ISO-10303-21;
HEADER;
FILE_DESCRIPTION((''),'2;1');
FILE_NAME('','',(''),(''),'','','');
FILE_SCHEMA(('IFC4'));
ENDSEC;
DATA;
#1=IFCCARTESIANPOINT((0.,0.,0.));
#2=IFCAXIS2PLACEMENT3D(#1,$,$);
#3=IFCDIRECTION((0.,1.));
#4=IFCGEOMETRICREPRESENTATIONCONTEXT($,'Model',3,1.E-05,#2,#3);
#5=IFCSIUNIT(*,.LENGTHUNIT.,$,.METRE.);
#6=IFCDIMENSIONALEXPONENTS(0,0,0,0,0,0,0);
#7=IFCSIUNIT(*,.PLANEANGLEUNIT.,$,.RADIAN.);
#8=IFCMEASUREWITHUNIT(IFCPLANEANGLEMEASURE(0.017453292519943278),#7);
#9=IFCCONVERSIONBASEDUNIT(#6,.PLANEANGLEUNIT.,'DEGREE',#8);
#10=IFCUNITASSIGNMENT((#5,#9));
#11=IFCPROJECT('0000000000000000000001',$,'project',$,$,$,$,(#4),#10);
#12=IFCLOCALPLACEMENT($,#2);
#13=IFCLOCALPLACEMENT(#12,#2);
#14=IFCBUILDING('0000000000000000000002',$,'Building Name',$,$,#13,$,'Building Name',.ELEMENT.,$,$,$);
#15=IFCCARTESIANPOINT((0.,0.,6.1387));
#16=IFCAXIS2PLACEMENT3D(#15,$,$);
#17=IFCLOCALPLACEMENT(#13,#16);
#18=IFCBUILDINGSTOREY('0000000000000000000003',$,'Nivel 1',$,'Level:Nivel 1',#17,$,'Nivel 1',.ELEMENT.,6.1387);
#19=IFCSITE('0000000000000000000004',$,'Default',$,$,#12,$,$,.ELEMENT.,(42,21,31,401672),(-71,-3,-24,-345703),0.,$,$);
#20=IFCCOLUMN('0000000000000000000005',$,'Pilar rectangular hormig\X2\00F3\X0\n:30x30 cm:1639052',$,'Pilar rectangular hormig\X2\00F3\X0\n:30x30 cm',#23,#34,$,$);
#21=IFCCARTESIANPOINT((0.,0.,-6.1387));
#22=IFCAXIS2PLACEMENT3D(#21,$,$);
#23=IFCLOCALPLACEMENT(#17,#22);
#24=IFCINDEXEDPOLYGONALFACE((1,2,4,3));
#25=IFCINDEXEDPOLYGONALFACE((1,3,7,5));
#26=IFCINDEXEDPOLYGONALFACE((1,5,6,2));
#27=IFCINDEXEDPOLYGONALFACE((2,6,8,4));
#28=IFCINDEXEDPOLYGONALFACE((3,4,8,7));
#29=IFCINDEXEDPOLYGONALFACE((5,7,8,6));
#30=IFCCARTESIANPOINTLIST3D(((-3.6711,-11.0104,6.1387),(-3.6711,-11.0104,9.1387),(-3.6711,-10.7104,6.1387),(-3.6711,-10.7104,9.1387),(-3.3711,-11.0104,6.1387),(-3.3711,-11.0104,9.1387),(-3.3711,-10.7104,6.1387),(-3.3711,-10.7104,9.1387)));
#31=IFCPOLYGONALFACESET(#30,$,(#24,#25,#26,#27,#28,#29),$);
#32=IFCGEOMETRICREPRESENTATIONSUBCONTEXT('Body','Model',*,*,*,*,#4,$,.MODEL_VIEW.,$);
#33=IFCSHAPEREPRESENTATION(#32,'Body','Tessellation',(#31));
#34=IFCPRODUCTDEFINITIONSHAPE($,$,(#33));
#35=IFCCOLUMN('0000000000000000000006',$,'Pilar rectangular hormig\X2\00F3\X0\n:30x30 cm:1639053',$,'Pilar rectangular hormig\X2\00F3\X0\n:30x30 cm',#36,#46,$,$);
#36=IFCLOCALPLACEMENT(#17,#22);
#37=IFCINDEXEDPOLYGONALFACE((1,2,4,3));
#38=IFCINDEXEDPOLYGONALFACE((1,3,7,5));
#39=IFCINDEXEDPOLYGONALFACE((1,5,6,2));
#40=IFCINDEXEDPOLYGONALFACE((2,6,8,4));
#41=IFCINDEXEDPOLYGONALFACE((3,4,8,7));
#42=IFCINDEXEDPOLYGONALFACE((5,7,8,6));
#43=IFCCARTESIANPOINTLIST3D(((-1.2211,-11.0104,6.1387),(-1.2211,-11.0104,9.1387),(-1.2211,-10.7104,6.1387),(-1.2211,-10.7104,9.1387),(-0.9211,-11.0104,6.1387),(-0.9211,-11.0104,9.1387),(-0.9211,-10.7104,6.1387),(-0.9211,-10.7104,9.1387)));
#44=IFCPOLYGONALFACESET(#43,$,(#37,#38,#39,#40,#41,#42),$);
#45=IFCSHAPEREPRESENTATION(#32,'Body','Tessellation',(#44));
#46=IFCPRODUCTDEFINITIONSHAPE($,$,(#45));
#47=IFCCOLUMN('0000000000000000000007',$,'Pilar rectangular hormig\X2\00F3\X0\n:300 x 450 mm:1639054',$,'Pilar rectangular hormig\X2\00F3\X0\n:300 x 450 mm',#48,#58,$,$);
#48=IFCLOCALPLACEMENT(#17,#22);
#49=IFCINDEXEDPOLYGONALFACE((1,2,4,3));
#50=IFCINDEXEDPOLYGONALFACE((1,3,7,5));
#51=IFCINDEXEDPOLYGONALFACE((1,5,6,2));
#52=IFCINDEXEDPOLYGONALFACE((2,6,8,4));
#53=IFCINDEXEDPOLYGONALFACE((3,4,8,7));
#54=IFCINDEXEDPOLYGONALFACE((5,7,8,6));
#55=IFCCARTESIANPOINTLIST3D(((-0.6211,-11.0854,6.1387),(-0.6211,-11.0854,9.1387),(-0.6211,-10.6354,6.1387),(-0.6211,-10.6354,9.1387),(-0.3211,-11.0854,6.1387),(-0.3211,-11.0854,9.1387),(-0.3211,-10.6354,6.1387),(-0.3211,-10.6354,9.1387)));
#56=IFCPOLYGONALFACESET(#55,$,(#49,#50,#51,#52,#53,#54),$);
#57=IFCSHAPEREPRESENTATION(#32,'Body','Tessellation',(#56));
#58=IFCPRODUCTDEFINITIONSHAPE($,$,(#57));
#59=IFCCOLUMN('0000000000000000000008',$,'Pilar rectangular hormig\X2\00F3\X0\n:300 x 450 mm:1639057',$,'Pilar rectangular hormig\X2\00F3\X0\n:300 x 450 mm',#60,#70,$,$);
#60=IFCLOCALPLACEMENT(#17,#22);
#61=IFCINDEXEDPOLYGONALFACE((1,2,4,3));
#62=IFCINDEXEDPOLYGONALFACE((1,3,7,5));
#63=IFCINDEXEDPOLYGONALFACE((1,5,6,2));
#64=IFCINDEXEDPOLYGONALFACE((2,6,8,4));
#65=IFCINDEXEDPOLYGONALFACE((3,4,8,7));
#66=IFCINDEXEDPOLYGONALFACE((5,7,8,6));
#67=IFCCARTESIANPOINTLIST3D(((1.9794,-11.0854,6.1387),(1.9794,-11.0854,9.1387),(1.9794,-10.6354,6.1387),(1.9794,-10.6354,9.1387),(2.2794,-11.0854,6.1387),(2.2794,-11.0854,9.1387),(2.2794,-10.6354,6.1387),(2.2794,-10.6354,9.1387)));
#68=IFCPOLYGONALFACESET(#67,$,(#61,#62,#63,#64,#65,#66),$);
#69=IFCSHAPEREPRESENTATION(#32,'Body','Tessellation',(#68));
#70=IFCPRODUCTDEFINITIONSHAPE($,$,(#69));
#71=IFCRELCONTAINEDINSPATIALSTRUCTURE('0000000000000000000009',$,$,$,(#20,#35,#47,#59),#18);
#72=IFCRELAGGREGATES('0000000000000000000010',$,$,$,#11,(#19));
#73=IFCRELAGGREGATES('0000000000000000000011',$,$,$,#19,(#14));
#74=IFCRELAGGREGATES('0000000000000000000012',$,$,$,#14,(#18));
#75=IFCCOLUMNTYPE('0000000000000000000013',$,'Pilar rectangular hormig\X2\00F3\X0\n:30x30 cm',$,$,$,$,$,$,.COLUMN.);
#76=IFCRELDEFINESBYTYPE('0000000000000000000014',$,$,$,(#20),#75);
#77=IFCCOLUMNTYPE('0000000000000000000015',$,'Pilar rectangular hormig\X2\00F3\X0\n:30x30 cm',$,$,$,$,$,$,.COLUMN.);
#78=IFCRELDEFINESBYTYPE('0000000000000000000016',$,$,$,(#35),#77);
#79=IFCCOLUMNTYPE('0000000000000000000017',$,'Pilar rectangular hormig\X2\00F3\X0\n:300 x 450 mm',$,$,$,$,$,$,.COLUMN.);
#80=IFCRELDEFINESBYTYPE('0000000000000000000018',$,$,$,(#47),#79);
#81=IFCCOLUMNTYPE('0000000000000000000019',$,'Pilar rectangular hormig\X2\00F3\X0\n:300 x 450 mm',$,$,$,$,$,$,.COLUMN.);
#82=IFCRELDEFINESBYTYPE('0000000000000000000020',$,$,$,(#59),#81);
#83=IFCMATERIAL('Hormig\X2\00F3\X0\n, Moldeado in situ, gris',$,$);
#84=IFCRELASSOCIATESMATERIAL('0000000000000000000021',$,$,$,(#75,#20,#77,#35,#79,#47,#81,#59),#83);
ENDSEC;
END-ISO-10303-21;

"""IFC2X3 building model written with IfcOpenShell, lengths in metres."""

from ifc_helpers import new_model, entity, si_unit, converted_unit, direction, frame, frame_2d, origin, place, context, subcontext, project, spatial, rectangle, extrude, source, transform, mapped, material, type_object, type_shapes, element, save


model = new_model("IFC2X3")

# Units and contexts
model_context = context("Model", 3, precision=1e-05, world=origin(), true_north=direction((0.0, 1.0)))
body_context = subcontext(model_context, "Body", "Model", "MODEL_VIEW")
ifc_project = project(units=[si_unit("LENGTHUNIT", "METRE"), converted_unit("PLANEANGLEUNIT", "DEGREE", entity("IfcPlaneAngleMeasure", 0.017453292519943278), si_unit("PLANEANGLEUNIT", "RADIAN"), dimensions=[0, 0, 0, 0, 0, 0, 0])], contexts=[model_context])

# Site, building, storey
site_placement = place(None, origin())
site = spatial("IfcSite", under=ifc_project, at=site_placement, Name="Default", CompositionType="ELEMENT", RefLatitude=(42, 21, 31, 401672), RefLongitude=(-71, -3, -24, -345703), RefElevation=0.0)
building_placement = place(site_placement, origin())
building = spatial("IfcBuilding", under=site, at=building_placement, Name="Building Name", LongName="Building Name", CompositionType="ELEMENT")
storey_placement = place(building_placement, frame((0.0, 0.0, 6.1387)))
storey = spatial("IfcBuildingStorey", under=building, at=storey_placement, Name="Nivel 1", ObjectType="Level:Nivel 1", LongName="Nivel 1", CompositionType="ELEMENT", Elevation=6.1387)

# Columns
ifc_material_1 = material(Name="Hormigón, Moldeado in situ, gris")
column_type_1 = type_object("IfcColumnType", Name="Pilar rectangular hormigón:30x30 cm", PredefinedType="COLUMN", material=ifc_material_1)
shared_shape_1 = source(origin(), body_context, "Body", "SweptSolid", [
    extrude(rectangle(XDim=0.3, YDim=0.3, at=frame_2d((0.0, 0.0), x_axis=(1.0, 0.0))), frame((-3.5211, -10.8604, 6.1387), z_axis=(0.0, 0.0, 1.0), x_axis=(-1.0, 0.0, 0.0)), (0.0, 0.0, 1.0), 3.0),
])
type_shapes(column_type_1, [shared_shape_1])
column_1_placement = place(storey_placement, frame((0.0, 0.0, -6.1387)))
element("IfcColumn", 1, at=column_1_placement, inside=storey, type_object=column_type_1, material=ifc_material_1, Name="Pilar rectangular hormigón:30x30 cm:1639052", ObjectType="Pilar rectangular hormigón:30x30 cm", context=body_context, shape_type="MappedRepresentation", body=[
    mapped(shared_shape_1, transform((0.0, 0.0, 0.0), scale=1.0)),
])
column_type_2 = type_object("IfcColumnType", Name="Pilar rectangular hormigón:30x30 cm", PredefinedType="COLUMN", material=ifc_material_1)
shared_shape_2 = source(origin(), body_context, "Body", "SweptSolid", [
    extrude(rectangle(XDim=0.3, YDim=0.3, at=frame_2d((0.0, 0.0), x_axis=(1.0, 0.0))), frame((-1.0711, -10.8604, 6.1387), z_axis=(0.0, 0.0, 1.0), x_axis=(-1.0, 0.0, 0.0)), (0.0, 0.0, 1.0), 3.0),
])
type_shapes(column_type_2, [shared_shape_2])
column_2_placement = place(storey_placement, frame((0.0, 0.0, -6.1387)))
element("IfcColumn", 2, at=column_2_placement, inside=storey, type_object=column_type_2, material=ifc_material_1, Name="Pilar rectangular hormigón:30x30 cm:1639053", ObjectType="Pilar rectangular hormigón:30x30 cm", context=body_context, shape_type="MappedRepresentation", body=[
    mapped(shared_shape_2, transform((0.0, 0.0, 0.0), scale=1.0)),
])
column_type_3 = type_object("IfcColumnType", Name="Pilar rectangular hormigón:300 x 450 mm", PredefinedType="COLUMN", material=ifc_material_1)
shared_shape_3 = source(origin(), body_context, "Body", "SweptSolid", [
    extrude(rectangle(XDim=0.3, YDim=0.45, at=frame_2d((0.0, 0.0), x_axis=(1.0, 0.0))), frame((-0.4711, -10.8604, 6.1387), z_axis=(0.0, 0.0, 1.0), x_axis=(-1.0, 0.0, 0.0)), (0.0, 0.0, 1.0), 3.0),
])
type_shapes(column_type_3, [shared_shape_3])
column_3_placement = place(storey_placement, frame((0.0, 0.0, -6.1387)))
element("IfcColumn", 3, at=column_3_placement, inside=storey, type_object=column_type_3, material=ifc_material_1, Name="Pilar rectangular hormigón:300 x 450 mm:1639054", ObjectType="Pilar rectangular hormigón:300 x 450 mm", context=body_context, shape_type="MappedRepresentation", body=[
    mapped(shared_shape_3, transform((0.0, 0.0, 0.0), scale=1.0)),
])
column_type_4 = type_object("IfcColumnType", Name="Pilar rectangular hormigón:300 x 450 mm", PredefinedType="COLUMN", material=ifc_material_1)
shared_shape_4 = source(origin(), body_context, "Body", "SweptSolid", [
    extrude(rectangle(XDim=0.3, YDim=0.45, at=frame_2d((0.0, 0.0), x_axis=(1.0, 0.0))), frame((2.1294, -10.8604, 6.1387), z_axis=(0.0, 0.0, 1.0), x_axis=(-1.0, 0.0, 0.0)), (0.0, 0.0, 1.0), 3.0),
])
type_shapes(column_type_4, [shared_shape_4])
column_4_placement = place(storey_placement, frame((0.0, 0.0, -6.1387)))
element("IfcColumn", 4, at=column_4_placement, inside=storey, type_object=column_type_4, material=ifc_material_1, Name="Pilar rectangular hormigón:300 x 450 mm:1639057", ObjectType="Pilar rectangular hormigón:300 x 450 mm", context=body_context, shape_type="MappedRepresentation", body=[
    mapped(shared_shape_4, transform((0.0, 0.0, 0.0), scale=1.0)),
])

save(model, "model.ifc")
